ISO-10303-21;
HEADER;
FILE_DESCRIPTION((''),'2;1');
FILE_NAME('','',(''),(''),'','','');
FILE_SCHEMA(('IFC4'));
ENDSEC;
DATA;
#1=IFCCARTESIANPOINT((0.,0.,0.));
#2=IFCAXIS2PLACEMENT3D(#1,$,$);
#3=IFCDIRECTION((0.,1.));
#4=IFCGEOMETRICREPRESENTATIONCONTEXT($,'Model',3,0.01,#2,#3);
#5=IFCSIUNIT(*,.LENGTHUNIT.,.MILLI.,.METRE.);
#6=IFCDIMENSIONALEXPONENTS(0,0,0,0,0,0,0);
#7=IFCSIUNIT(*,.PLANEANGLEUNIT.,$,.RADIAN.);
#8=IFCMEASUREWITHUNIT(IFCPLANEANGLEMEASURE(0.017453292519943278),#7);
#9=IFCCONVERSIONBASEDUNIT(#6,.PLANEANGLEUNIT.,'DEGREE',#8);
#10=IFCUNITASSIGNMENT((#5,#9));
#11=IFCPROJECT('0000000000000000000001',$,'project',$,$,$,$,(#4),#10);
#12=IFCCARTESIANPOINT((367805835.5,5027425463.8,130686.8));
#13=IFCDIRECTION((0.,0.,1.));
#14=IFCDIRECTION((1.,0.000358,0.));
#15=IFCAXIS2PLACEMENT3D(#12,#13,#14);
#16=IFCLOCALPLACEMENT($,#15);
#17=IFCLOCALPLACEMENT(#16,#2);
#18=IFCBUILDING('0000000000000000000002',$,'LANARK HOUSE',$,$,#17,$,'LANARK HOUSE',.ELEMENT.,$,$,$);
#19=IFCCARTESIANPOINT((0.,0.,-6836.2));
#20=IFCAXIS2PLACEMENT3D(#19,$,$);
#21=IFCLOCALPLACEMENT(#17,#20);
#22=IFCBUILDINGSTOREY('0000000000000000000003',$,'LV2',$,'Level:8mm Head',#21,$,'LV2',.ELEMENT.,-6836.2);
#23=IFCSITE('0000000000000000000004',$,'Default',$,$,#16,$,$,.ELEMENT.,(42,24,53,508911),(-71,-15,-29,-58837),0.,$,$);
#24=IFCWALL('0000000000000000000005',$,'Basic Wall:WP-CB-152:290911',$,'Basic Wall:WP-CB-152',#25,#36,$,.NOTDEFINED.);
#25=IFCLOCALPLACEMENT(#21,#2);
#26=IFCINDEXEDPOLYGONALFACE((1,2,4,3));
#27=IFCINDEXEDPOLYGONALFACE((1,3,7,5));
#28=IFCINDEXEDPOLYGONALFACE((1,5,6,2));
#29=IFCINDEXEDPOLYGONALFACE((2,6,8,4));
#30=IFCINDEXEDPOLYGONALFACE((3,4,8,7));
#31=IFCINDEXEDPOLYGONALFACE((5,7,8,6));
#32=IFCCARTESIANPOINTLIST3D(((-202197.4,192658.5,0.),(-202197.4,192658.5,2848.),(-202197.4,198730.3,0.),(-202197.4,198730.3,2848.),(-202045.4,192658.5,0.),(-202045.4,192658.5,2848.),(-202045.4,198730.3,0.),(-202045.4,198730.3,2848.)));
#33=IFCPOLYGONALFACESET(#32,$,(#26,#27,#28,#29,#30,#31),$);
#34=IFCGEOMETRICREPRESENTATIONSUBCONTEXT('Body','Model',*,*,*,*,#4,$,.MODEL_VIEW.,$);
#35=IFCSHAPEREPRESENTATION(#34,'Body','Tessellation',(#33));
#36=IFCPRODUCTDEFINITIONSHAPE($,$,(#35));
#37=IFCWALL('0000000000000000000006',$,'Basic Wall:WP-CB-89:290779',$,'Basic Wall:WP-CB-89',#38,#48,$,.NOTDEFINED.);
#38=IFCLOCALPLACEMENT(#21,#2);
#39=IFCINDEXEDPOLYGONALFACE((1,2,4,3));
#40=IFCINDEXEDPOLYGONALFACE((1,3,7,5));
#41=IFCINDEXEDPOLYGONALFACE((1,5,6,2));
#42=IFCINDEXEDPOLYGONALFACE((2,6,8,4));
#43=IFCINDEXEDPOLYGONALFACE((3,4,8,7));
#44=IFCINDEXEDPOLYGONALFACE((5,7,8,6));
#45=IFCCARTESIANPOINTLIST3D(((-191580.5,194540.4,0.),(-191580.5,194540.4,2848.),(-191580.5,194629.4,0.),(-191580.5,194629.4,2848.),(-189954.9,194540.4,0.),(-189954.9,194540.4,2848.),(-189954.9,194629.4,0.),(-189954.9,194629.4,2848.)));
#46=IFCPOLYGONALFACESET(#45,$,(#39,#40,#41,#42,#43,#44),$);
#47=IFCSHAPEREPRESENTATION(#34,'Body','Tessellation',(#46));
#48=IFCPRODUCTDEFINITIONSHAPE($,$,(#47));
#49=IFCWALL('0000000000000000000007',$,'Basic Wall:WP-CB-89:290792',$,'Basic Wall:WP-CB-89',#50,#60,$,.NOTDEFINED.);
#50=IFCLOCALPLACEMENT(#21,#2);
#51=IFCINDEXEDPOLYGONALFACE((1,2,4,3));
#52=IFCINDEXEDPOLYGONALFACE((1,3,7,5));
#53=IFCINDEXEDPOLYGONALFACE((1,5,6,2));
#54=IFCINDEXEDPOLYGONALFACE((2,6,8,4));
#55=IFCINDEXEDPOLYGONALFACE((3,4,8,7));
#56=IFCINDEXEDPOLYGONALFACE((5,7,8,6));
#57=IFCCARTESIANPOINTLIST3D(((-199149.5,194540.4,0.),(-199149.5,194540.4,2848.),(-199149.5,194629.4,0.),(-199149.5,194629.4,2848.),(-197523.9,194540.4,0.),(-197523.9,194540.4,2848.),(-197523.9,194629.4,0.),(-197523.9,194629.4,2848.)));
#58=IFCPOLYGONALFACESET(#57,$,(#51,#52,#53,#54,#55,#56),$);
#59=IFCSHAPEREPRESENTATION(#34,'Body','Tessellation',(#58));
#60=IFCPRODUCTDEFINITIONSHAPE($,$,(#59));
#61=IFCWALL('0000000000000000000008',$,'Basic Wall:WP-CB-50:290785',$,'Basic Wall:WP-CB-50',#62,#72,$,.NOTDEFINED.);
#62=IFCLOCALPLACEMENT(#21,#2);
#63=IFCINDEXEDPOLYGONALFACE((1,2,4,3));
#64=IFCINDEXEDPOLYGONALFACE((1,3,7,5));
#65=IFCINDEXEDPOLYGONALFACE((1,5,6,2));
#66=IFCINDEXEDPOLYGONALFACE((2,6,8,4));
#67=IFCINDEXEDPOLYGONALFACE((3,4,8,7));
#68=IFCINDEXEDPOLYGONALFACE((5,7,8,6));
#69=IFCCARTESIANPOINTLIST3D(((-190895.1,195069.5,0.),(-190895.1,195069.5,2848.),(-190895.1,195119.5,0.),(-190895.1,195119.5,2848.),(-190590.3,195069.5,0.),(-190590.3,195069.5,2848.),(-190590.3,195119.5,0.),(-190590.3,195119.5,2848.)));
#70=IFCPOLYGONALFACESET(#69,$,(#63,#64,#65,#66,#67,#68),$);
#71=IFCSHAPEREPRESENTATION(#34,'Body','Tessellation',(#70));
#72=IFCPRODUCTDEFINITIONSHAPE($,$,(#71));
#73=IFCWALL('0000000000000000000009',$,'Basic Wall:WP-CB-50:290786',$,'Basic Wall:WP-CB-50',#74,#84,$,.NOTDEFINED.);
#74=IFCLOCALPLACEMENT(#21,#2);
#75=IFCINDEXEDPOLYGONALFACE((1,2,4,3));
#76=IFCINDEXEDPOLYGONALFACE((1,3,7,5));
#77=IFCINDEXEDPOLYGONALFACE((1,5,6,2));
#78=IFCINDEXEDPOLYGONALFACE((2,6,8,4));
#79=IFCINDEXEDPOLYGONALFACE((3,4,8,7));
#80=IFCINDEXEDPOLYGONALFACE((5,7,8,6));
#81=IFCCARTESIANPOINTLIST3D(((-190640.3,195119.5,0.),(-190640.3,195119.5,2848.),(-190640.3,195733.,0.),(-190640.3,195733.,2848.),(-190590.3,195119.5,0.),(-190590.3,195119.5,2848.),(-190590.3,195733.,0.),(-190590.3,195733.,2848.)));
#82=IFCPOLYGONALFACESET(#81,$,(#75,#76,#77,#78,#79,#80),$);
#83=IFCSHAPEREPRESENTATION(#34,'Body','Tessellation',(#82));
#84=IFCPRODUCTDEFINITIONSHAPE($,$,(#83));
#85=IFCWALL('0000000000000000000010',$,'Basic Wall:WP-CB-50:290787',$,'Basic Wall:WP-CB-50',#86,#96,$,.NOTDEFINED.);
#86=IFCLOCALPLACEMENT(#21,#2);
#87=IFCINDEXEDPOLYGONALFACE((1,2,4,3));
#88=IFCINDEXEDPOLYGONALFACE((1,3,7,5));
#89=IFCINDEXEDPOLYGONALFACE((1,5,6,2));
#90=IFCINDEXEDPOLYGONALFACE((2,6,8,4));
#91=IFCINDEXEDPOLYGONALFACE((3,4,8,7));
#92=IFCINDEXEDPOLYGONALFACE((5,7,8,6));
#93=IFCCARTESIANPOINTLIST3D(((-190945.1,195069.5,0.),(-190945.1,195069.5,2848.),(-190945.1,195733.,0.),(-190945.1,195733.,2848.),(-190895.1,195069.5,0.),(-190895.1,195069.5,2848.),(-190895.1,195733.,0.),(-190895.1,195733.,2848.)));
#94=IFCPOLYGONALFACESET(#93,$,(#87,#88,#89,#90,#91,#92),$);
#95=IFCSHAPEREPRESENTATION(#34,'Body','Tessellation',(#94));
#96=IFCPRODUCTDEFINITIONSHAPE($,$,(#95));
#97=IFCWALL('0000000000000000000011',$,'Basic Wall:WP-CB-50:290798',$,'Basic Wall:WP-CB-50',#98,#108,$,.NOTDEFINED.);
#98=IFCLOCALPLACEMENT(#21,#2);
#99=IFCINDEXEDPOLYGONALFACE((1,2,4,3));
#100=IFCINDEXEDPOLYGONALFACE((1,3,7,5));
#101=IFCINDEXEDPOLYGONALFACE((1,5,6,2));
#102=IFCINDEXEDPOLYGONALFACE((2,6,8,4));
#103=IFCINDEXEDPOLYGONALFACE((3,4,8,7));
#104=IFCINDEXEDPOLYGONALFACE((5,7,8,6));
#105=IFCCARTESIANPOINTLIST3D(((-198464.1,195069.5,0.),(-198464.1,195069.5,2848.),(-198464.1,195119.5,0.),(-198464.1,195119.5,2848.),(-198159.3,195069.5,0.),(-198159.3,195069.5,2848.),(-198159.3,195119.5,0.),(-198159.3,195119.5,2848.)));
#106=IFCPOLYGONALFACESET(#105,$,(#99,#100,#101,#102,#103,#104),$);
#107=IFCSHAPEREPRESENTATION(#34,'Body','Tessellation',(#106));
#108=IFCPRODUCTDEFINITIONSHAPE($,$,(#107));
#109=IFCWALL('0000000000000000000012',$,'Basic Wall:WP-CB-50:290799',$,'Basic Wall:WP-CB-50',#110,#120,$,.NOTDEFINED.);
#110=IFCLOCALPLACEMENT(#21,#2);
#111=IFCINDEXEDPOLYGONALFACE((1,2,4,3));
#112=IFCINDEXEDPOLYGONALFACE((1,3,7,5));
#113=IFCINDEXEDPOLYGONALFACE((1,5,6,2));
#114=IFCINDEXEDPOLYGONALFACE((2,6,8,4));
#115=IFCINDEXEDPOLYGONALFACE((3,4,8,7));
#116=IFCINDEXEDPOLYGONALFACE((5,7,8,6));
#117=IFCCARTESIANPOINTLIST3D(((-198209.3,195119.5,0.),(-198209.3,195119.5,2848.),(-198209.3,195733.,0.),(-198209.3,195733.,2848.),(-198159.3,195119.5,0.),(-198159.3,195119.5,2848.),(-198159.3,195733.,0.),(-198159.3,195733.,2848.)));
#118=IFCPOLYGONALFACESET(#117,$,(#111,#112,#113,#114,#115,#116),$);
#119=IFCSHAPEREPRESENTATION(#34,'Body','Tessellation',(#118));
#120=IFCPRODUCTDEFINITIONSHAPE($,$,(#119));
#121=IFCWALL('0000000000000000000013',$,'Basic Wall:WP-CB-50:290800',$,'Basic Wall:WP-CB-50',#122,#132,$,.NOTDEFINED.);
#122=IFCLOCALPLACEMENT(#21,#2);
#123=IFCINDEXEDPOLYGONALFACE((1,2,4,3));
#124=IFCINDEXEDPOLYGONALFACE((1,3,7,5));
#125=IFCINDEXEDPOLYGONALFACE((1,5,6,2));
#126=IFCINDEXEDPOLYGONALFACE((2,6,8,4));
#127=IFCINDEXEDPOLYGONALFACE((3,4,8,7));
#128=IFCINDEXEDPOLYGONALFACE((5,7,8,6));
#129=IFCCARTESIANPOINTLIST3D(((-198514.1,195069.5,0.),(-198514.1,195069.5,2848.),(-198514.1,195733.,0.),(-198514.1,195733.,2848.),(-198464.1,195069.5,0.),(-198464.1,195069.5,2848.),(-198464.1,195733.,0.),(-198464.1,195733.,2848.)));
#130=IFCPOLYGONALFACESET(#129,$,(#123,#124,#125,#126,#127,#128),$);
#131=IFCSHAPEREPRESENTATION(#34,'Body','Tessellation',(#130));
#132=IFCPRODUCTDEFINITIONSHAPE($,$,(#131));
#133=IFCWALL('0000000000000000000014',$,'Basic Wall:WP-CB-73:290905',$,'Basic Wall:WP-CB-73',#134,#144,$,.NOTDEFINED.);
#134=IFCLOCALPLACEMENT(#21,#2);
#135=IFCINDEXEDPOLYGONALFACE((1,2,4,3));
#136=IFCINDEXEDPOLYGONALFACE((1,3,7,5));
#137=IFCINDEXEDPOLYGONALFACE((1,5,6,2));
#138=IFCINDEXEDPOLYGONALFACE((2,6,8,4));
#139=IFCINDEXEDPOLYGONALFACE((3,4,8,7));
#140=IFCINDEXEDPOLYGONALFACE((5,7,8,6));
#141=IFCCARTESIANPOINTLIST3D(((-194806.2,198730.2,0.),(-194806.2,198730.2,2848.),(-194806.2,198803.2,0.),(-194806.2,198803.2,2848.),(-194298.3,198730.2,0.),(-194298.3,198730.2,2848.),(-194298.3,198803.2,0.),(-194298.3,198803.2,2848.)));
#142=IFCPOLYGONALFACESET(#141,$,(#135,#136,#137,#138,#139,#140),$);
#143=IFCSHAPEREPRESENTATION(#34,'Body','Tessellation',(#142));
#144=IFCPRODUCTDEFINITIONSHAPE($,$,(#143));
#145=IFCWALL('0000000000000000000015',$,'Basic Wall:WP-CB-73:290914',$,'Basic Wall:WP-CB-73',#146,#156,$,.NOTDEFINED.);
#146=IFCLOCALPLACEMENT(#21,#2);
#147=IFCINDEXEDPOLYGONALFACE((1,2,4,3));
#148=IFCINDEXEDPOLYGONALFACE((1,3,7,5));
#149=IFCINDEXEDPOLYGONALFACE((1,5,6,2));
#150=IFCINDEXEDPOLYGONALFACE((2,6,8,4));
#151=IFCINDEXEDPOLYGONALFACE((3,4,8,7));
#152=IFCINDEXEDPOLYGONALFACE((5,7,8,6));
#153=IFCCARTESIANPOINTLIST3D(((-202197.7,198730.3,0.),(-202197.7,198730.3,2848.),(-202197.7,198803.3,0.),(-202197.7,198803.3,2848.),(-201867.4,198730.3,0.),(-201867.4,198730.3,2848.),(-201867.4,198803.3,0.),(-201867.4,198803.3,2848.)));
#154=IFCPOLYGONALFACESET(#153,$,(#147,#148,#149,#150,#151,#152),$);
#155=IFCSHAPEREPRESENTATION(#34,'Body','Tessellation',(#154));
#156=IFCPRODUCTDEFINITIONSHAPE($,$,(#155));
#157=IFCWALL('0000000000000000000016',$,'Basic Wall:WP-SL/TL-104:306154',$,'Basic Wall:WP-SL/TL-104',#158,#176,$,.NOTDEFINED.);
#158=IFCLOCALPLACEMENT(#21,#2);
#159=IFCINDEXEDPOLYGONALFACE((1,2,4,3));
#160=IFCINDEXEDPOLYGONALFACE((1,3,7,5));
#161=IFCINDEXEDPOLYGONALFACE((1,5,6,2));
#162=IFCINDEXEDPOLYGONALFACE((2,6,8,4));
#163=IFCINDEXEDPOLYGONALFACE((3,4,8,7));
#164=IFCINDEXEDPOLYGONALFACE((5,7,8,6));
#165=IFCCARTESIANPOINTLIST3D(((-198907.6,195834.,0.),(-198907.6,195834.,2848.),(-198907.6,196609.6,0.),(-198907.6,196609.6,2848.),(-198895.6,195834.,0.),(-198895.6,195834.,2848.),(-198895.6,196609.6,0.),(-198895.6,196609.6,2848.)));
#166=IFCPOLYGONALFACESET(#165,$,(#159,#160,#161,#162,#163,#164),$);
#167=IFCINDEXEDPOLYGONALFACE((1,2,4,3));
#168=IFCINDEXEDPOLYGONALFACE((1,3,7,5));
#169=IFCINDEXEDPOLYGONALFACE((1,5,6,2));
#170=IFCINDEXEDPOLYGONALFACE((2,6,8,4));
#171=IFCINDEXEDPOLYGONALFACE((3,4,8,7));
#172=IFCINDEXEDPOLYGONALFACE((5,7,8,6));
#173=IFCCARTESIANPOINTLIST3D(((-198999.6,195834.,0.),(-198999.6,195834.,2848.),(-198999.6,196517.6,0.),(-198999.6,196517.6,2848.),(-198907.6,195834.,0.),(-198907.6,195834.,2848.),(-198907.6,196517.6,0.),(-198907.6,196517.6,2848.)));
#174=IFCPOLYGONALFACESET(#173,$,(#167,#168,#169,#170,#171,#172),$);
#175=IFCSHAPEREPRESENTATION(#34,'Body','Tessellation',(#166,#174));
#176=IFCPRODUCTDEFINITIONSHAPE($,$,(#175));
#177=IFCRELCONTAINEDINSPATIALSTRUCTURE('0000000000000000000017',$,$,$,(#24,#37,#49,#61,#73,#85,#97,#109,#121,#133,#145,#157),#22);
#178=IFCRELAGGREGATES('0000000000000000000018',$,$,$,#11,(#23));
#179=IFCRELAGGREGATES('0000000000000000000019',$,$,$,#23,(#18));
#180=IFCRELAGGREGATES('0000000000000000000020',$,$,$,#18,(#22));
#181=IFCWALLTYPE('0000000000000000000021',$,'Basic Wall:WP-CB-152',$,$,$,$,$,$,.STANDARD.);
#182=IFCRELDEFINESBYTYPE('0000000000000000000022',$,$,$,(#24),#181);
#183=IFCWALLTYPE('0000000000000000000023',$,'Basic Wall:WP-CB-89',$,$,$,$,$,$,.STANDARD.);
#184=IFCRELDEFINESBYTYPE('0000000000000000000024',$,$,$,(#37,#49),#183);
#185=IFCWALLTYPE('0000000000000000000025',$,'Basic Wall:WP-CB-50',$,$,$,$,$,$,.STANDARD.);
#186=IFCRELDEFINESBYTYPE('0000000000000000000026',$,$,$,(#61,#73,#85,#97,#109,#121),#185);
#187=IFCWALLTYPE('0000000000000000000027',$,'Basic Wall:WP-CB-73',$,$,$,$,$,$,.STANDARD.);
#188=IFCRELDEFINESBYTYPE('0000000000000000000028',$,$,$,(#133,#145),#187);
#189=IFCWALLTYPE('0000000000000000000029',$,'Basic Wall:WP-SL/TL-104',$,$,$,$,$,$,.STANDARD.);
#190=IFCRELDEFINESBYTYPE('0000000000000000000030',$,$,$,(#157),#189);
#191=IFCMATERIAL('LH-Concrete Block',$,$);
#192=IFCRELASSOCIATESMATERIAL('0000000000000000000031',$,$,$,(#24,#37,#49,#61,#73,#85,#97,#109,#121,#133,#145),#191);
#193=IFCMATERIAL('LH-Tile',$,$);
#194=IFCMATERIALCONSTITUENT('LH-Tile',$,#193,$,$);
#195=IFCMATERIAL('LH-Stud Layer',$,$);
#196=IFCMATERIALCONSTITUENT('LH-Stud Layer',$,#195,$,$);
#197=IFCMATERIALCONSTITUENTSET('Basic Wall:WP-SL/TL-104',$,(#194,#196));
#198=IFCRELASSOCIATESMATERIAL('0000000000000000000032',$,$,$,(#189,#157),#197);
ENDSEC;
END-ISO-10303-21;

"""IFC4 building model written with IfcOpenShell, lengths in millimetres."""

from ifc_helpers import new_model, entity, si_unit, converted_unit, direction, frame, origin, place, context, subcontext, project, spatial, indexed_curve, outline, extrude, material, constituent, constituent_set, type_object, element, save


model = new_model("IFC4")

# Units and contexts
model_context = context("Model", 3, precision=0.01, world=origin(), true_north=direction((0.0, 1.0)))
body_context = subcontext(model_context, "Body", "Model", "MODEL_VIEW")
ifc_project = project(units=[si_unit("LENGTHUNIT", "METRE", prefix="MILLI"), converted_unit("PLANEANGLEUNIT", "DEGREE", entity("IfcPlaneAngleMeasure", 0.017453292519943278), si_unit("PLANEANGLEUNIT", "RADIAN"), dimensions=[0, 0, 0, 0, 0, 0, 0])], contexts=[model_context])

# Site, building, storey
site_placement = place(None, frame((367805835.5, 5027425463.8, 130686.8), z_axis=(0.0, 0.0, 1.0), x_axis=(1.0, 0.000358, 0.0)))
site = spatial("IfcSite", under=ifc_project, at=site_placement, Name="Default", CompositionType="ELEMENT", RefLatitude=(42, 24, 53, 508911), RefLongitude=(-71, -15, -29, -58837), RefElevation=0.0)
building_placement = place(site_placement, origin())
building = spatial("IfcBuilding", under=site, at=building_placement, Name="LANARK HOUSE", LongName="LANARK HOUSE", CompositionType="ELEMENT")
storey_placement = place(building_placement, frame((0.0, 0.0, -6836.2)))
storey = spatial("IfcBuildingStorey", under=building, at=storey_placement, Name="LV2", ObjectType="Level:8mm Head", LongName="LV2", CompositionType="ELEMENT", Elevation=-6836.2)

# Walls
ifc_material_1 = material(Name="LH-Concrete Block")
wall_type_1 = type_object("IfcWallType", Name="Basic Wall:WP-CB-152", PredefinedType="STANDARD")
wall_1_placement = place(storey_placement, frame((-202121.4, 192658.5, 0.0), z_axis=(0.0, 0.0, 1.0), x_axis=(0.0, 1.0, 0.0)))
element("IfcWall", 1, at=wall_1_placement, inside=storey, type_object=wall_type_1, material=ifc_material_1, Name="Basic Wall:WP-CB-152:290911", ObjectType="Basic Wall:WP-CB-152", PredefinedType="NOTDEFINED", context=body_context, shape_type="SweptSolid", body=[
    extrude(outline(indexed_curve([(6071.8, 76.0), (0.0, 76.0), (0.0, -76.0), (6071.8, -76.0), (6071.8, 76.0)], self_intersect=False)), origin(), (0.0, 0.0, 1.0), 2848.0),
])
wall_type_2 = type_object("IfcWallType", Name="Basic Wall:WP-CB-89", PredefinedType="STANDARD")
for number, where, name in (
    (2, (-191580.5, 194584.9, 0.0), "Basic Wall:WP-CB-89:290779"),
    (3, (-199149.5, 194584.9, 0.0), "Basic Wall:WP-CB-89:290792"),
):
    element("IfcWall", number, at=place(storey_placement, frame(where)), inside=storey, type_object=wall_type_2, material=ifc_material_1, Name=name, ObjectType="Basic Wall:WP-CB-89", PredefinedType="NOTDEFINED", context=body_context, shape_type="SweptSolid", body=[
        extrude(outline(indexed_curve([(1625.6, 44.5), (0.0, 44.5), (0.0, -44.5), (1625.6, -44.5), (1625.6, 44.5)], self_intersect=False)), origin(), (0.0, 0.0, 1.0), 2848.0),
    ])
wall_type_3 = type_object("IfcWallType", Name="Basic Wall:WP-CB-50", PredefinedType="STANDARD")
wall_2_placement = place(storey_placement, frame((-190590.3, 195094.5, 0.0), z_axis=(0.0, 0.0, 1.0), x_axis=(-1.0, 0.0, 0.0)))
element("IfcWall", 4, at=wall_2_placement, inside=storey, type_object=wall_type_3, material=ifc_material_1, Name="Basic Wall:WP-CB-50:290785", ObjectType="Basic Wall:WP-CB-50", PredefinedType="NOTDEFINED", context=body_context, shape_type="SweptSolid", body=[
    extrude(outline(indexed_curve([(304.8, 25.0), (0.0, 25.0), (0.0, -25.0), (304.8, -25.0), (304.8, 25.0)], self_intersect=False)), origin(), (0.0, 0.0, 1.0), 2848.0),
])
wall_3_placement = place(storey_placement, frame((-190615.3, 195733.0, 0.0), z_axis=(0.0, 0.0, 1.0), x_axis=(0.0, -1.0, 0.0)))
element("IfcWall", 5, at=wall_3_placement, inside=storey, type_object=wall_type_3, material=ifc_material_1, Name="Basic Wall:WP-CB-50:290786", ObjectType="Basic Wall:WP-CB-50", PredefinedType="NOTDEFINED", context=body_context, shape_type="SweptSolid", body=[
    extrude(outline(indexed_curve([(613.5, 25.0), (0.0, 25.0), (0.0, -25.0), (613.5, -25.0), (613.5, 25.0)], self_intersect=False)), origin(), (0.0, 0.0, 1.0), 2848.0),
])
wall_4_placement = place(storey_placement, frame((-190920.1, 195733.0, 0.0), z_axis=(0.0, 0.0, 1.0), x_axis=(0.0, -1.0, 0.0)))
element("IfcWall", 6, at=wall_4_placement, inside=storey, type_object=wall_type_3, material=ifc_material_1, Name="Basic Wall:WP-CB-50:290787", ObjectType="Basic Wall:WP-CB-50", PredefinedType="NOTDEFINED", context=body_context, shape_type="SweptSolid", body=[
    extrude(outline(indexed_curve([(663.5, 25.0), (0.0, 25.0), (0.0, -25.0), (663.5, -25.0), (663.5, 25.0)], self_intersect=False)), origin(), (0.0, 0.0, 1.0), 2848.0),
])
wall_5_placement = place(storey_placement, frame((-198159.3, 195094.5, 0.0), z_axis=(0.0, 0.0, 1.0), x_axis=(-1.0, 0.0, 0.0)))
element("IfcWall", 7, at=wall_5_placement, inside=storey, type_object=wall_type_3, material=ifc_material_1, Name="Basic Wall:WP-CB-50:290798", ObjectType="Basic Wall:WP-CB-50", PredefinedType="NOTDEFINED", context=body_context, shape_type="SweptSolid", body=[
    extrude(outline(indexed_curve([(304.8, 25.0), (0.0, 25.0), (0.0, -25.0), (304.8, -25.0), (304.8, 25.0)], self_intersect=False)), origin(), (0.0, 0.0, 1.0), 2848.0),
])
wall_6_placement = place(storey_placement, frame((-198184.3, 195733.0, 0.0), z_axis=(0.0, 0.0, 1.0), x_axis=(0.0, -1.0, 0.0)))
element("IfcWall", 8, at=wall_6_placement, inside=storey, type_object=wall_type_3, material=ifc_material_1, Name="Basic Wall:WP-CB-50:290799", ObjectType="Basic Wall:WP-CB-50", PredefinedType="NOTDEFINED", context=body_context, shape_type="SweptSolid", body=[
    extrude(outline(indexed_curve([(613.5, 25.0), (0.0, 25.0), (0.0, -25.0), (613.5, -25.0), (613.5, 25.0)], self_intersect=False)), origin(), (0.0, 0.0, 1.0), 2848.0),
])
wall_7_placement = place(storey_placement, frame((-198489.1, 195733.0, 0.0), z_axis=(0.0, 0.0, 1.0), x_axis=(0.0, -1.0, 0.0)))
element("IfcWall", 9, at=wall_7_placement, inside=storey, type_object=wall_type_3, material=ifc_material_1, Name="Basic Wall:WP-CB-50:290800", ObjectType="Basic Wall:WP-CB-50", PredefinedType="NOTDEFINED", context=body_context, shape_type="SweptSolid", body=[
    extrude(outline(indexed_curve([(663.5, 25.0), (0.0, 25.0), (0.0, -25.0), (663.5, -25.0), (663.5, 25.0)], self_intersect=False)), origin(), (0.0, 0.0, 1.0), 2848.0),
])
wall_type_4 = type_object("IfcWallType", Name="Basic Wall:WP-CB-73", PredefinedType="STANDARD")
wall_8_placement = place(storey_placement, frame((-194298.3, 198766.7, 0.0), z_axis=(0.0, 0.0, 1.0), x_axis=(-1.0, 0.0, 0.0)))
element("IfcWall", 10, at=wall_8_placement, inside=storey, type_object=wall_type_4, material=ifc_material_1, Name="Basic Wall:WP-CB-73:290905", ObjectType="Basic Wall:WP-CB-73", PredefinedType="NOTDEFINED", context=body_context, shape_type="SweptSolid", body=[
    extrude(outline(indexed_curve([(507.9, 36.5), (0.0, 36.5), (0.0, -36.5), (507.9, -36.5), (507.9, 36.5)], self_intersect=False)), origin(), (0.0, 0.0, 1.0), 2848.0),
])
wall_9_placement = place(storey_placement, frame((-201867.4, 198766.8, 0.0), z_axis=(0.0, 0.0, 1.0), x_axis=(-1.0, 0.0, 0.0)))
element("IfcWall", 11, at=wall_9_placement, inside=storey, type_object=wall_type_4, material=ifc_material_1, Name="Basic Wall:WP-CB-73:290914", ObjectType="Basic Wall:WP-CB-73", PredefinedType="NOTDEFINED", context=body_context, shape_type="SweptSolid", body=[
    extrude(outline(indexed_curve([(330.3, 36.5), (0.0, 36.5), (0.0, -36.5), (330.3, -36.5), (330.3, 36.5)], self_intersect=False)), origin(), (0.0, 0.0, 1.0), 2848.0),
])
ifc_material_2 = material(Name="LH-Tile")
ifc_constituent_1 = constituent(ifc_material_2, Name="LH-Tile")
ifc_material_3 = material(Name="LH-Stud Layer")
ifc_constituent_2 = constituent(ifc_material_3, Name="LH-Stud Layer")
ifc_constituent_set_1 = constituent_set(constituents=[ifc_constituent_1, ifc_constituent_2], Name="Basic Wall:WP-SL/TL-104")
wall_type_5 = type_object("IfcWallType", Name="Basic Wall:WP-SL/TL-104", PredefinedType="STANDARD", material=ifc_constituent_set_1)
wall_10_placement = place(storey_placement, frame((-198947.6, 196517.6, 0.0), z_axis=(0.0, 0.0, 1.0), x_axis=(0.0, -1.0, 0.0)))
element("IfcWall", 12, at=wall_10_placement, inside=storey, type_object=wall_type_5, material=ifc_constituent_set_1, Name="Basic Wall:WP-SL/TL-104:306154", ObjectType="Basic Wall:WP-SL/TL-104", PredefinedType="NOTDEFINED", context=body_context, shape_type="SweptSolid", body=[
    extrude(outline(indexed_curve([(-6.0, -387.8), (6.0, -387.8), (6.0, 387.8), (-6.0, 387.8), (-6.0, -387.8)], self_intersect=False)), frame((295.8, 46.0, 0.0), z_axis=(0.0, 0.0, 1.0), x_axis=(0.0, -1.0, 0.0)), (0.0, 0.0, 1.0), 2848.0),
    extrude(outline(indexed_curve([(-46.0, -341.8), (46.0, -341.8), (46.0, 341.8), (-46.0, 341.8), (-46.0, -341.8)], self_intersect=False)), frame((341.8, -6.0, 0.0), z_axis=(0.0, 0.0, 1.0), x_axis=(0.0, 1.0, 0.0)), (0.0, 0.0, 1.0), 2848.0),
])

save(model, "model.ifc")
